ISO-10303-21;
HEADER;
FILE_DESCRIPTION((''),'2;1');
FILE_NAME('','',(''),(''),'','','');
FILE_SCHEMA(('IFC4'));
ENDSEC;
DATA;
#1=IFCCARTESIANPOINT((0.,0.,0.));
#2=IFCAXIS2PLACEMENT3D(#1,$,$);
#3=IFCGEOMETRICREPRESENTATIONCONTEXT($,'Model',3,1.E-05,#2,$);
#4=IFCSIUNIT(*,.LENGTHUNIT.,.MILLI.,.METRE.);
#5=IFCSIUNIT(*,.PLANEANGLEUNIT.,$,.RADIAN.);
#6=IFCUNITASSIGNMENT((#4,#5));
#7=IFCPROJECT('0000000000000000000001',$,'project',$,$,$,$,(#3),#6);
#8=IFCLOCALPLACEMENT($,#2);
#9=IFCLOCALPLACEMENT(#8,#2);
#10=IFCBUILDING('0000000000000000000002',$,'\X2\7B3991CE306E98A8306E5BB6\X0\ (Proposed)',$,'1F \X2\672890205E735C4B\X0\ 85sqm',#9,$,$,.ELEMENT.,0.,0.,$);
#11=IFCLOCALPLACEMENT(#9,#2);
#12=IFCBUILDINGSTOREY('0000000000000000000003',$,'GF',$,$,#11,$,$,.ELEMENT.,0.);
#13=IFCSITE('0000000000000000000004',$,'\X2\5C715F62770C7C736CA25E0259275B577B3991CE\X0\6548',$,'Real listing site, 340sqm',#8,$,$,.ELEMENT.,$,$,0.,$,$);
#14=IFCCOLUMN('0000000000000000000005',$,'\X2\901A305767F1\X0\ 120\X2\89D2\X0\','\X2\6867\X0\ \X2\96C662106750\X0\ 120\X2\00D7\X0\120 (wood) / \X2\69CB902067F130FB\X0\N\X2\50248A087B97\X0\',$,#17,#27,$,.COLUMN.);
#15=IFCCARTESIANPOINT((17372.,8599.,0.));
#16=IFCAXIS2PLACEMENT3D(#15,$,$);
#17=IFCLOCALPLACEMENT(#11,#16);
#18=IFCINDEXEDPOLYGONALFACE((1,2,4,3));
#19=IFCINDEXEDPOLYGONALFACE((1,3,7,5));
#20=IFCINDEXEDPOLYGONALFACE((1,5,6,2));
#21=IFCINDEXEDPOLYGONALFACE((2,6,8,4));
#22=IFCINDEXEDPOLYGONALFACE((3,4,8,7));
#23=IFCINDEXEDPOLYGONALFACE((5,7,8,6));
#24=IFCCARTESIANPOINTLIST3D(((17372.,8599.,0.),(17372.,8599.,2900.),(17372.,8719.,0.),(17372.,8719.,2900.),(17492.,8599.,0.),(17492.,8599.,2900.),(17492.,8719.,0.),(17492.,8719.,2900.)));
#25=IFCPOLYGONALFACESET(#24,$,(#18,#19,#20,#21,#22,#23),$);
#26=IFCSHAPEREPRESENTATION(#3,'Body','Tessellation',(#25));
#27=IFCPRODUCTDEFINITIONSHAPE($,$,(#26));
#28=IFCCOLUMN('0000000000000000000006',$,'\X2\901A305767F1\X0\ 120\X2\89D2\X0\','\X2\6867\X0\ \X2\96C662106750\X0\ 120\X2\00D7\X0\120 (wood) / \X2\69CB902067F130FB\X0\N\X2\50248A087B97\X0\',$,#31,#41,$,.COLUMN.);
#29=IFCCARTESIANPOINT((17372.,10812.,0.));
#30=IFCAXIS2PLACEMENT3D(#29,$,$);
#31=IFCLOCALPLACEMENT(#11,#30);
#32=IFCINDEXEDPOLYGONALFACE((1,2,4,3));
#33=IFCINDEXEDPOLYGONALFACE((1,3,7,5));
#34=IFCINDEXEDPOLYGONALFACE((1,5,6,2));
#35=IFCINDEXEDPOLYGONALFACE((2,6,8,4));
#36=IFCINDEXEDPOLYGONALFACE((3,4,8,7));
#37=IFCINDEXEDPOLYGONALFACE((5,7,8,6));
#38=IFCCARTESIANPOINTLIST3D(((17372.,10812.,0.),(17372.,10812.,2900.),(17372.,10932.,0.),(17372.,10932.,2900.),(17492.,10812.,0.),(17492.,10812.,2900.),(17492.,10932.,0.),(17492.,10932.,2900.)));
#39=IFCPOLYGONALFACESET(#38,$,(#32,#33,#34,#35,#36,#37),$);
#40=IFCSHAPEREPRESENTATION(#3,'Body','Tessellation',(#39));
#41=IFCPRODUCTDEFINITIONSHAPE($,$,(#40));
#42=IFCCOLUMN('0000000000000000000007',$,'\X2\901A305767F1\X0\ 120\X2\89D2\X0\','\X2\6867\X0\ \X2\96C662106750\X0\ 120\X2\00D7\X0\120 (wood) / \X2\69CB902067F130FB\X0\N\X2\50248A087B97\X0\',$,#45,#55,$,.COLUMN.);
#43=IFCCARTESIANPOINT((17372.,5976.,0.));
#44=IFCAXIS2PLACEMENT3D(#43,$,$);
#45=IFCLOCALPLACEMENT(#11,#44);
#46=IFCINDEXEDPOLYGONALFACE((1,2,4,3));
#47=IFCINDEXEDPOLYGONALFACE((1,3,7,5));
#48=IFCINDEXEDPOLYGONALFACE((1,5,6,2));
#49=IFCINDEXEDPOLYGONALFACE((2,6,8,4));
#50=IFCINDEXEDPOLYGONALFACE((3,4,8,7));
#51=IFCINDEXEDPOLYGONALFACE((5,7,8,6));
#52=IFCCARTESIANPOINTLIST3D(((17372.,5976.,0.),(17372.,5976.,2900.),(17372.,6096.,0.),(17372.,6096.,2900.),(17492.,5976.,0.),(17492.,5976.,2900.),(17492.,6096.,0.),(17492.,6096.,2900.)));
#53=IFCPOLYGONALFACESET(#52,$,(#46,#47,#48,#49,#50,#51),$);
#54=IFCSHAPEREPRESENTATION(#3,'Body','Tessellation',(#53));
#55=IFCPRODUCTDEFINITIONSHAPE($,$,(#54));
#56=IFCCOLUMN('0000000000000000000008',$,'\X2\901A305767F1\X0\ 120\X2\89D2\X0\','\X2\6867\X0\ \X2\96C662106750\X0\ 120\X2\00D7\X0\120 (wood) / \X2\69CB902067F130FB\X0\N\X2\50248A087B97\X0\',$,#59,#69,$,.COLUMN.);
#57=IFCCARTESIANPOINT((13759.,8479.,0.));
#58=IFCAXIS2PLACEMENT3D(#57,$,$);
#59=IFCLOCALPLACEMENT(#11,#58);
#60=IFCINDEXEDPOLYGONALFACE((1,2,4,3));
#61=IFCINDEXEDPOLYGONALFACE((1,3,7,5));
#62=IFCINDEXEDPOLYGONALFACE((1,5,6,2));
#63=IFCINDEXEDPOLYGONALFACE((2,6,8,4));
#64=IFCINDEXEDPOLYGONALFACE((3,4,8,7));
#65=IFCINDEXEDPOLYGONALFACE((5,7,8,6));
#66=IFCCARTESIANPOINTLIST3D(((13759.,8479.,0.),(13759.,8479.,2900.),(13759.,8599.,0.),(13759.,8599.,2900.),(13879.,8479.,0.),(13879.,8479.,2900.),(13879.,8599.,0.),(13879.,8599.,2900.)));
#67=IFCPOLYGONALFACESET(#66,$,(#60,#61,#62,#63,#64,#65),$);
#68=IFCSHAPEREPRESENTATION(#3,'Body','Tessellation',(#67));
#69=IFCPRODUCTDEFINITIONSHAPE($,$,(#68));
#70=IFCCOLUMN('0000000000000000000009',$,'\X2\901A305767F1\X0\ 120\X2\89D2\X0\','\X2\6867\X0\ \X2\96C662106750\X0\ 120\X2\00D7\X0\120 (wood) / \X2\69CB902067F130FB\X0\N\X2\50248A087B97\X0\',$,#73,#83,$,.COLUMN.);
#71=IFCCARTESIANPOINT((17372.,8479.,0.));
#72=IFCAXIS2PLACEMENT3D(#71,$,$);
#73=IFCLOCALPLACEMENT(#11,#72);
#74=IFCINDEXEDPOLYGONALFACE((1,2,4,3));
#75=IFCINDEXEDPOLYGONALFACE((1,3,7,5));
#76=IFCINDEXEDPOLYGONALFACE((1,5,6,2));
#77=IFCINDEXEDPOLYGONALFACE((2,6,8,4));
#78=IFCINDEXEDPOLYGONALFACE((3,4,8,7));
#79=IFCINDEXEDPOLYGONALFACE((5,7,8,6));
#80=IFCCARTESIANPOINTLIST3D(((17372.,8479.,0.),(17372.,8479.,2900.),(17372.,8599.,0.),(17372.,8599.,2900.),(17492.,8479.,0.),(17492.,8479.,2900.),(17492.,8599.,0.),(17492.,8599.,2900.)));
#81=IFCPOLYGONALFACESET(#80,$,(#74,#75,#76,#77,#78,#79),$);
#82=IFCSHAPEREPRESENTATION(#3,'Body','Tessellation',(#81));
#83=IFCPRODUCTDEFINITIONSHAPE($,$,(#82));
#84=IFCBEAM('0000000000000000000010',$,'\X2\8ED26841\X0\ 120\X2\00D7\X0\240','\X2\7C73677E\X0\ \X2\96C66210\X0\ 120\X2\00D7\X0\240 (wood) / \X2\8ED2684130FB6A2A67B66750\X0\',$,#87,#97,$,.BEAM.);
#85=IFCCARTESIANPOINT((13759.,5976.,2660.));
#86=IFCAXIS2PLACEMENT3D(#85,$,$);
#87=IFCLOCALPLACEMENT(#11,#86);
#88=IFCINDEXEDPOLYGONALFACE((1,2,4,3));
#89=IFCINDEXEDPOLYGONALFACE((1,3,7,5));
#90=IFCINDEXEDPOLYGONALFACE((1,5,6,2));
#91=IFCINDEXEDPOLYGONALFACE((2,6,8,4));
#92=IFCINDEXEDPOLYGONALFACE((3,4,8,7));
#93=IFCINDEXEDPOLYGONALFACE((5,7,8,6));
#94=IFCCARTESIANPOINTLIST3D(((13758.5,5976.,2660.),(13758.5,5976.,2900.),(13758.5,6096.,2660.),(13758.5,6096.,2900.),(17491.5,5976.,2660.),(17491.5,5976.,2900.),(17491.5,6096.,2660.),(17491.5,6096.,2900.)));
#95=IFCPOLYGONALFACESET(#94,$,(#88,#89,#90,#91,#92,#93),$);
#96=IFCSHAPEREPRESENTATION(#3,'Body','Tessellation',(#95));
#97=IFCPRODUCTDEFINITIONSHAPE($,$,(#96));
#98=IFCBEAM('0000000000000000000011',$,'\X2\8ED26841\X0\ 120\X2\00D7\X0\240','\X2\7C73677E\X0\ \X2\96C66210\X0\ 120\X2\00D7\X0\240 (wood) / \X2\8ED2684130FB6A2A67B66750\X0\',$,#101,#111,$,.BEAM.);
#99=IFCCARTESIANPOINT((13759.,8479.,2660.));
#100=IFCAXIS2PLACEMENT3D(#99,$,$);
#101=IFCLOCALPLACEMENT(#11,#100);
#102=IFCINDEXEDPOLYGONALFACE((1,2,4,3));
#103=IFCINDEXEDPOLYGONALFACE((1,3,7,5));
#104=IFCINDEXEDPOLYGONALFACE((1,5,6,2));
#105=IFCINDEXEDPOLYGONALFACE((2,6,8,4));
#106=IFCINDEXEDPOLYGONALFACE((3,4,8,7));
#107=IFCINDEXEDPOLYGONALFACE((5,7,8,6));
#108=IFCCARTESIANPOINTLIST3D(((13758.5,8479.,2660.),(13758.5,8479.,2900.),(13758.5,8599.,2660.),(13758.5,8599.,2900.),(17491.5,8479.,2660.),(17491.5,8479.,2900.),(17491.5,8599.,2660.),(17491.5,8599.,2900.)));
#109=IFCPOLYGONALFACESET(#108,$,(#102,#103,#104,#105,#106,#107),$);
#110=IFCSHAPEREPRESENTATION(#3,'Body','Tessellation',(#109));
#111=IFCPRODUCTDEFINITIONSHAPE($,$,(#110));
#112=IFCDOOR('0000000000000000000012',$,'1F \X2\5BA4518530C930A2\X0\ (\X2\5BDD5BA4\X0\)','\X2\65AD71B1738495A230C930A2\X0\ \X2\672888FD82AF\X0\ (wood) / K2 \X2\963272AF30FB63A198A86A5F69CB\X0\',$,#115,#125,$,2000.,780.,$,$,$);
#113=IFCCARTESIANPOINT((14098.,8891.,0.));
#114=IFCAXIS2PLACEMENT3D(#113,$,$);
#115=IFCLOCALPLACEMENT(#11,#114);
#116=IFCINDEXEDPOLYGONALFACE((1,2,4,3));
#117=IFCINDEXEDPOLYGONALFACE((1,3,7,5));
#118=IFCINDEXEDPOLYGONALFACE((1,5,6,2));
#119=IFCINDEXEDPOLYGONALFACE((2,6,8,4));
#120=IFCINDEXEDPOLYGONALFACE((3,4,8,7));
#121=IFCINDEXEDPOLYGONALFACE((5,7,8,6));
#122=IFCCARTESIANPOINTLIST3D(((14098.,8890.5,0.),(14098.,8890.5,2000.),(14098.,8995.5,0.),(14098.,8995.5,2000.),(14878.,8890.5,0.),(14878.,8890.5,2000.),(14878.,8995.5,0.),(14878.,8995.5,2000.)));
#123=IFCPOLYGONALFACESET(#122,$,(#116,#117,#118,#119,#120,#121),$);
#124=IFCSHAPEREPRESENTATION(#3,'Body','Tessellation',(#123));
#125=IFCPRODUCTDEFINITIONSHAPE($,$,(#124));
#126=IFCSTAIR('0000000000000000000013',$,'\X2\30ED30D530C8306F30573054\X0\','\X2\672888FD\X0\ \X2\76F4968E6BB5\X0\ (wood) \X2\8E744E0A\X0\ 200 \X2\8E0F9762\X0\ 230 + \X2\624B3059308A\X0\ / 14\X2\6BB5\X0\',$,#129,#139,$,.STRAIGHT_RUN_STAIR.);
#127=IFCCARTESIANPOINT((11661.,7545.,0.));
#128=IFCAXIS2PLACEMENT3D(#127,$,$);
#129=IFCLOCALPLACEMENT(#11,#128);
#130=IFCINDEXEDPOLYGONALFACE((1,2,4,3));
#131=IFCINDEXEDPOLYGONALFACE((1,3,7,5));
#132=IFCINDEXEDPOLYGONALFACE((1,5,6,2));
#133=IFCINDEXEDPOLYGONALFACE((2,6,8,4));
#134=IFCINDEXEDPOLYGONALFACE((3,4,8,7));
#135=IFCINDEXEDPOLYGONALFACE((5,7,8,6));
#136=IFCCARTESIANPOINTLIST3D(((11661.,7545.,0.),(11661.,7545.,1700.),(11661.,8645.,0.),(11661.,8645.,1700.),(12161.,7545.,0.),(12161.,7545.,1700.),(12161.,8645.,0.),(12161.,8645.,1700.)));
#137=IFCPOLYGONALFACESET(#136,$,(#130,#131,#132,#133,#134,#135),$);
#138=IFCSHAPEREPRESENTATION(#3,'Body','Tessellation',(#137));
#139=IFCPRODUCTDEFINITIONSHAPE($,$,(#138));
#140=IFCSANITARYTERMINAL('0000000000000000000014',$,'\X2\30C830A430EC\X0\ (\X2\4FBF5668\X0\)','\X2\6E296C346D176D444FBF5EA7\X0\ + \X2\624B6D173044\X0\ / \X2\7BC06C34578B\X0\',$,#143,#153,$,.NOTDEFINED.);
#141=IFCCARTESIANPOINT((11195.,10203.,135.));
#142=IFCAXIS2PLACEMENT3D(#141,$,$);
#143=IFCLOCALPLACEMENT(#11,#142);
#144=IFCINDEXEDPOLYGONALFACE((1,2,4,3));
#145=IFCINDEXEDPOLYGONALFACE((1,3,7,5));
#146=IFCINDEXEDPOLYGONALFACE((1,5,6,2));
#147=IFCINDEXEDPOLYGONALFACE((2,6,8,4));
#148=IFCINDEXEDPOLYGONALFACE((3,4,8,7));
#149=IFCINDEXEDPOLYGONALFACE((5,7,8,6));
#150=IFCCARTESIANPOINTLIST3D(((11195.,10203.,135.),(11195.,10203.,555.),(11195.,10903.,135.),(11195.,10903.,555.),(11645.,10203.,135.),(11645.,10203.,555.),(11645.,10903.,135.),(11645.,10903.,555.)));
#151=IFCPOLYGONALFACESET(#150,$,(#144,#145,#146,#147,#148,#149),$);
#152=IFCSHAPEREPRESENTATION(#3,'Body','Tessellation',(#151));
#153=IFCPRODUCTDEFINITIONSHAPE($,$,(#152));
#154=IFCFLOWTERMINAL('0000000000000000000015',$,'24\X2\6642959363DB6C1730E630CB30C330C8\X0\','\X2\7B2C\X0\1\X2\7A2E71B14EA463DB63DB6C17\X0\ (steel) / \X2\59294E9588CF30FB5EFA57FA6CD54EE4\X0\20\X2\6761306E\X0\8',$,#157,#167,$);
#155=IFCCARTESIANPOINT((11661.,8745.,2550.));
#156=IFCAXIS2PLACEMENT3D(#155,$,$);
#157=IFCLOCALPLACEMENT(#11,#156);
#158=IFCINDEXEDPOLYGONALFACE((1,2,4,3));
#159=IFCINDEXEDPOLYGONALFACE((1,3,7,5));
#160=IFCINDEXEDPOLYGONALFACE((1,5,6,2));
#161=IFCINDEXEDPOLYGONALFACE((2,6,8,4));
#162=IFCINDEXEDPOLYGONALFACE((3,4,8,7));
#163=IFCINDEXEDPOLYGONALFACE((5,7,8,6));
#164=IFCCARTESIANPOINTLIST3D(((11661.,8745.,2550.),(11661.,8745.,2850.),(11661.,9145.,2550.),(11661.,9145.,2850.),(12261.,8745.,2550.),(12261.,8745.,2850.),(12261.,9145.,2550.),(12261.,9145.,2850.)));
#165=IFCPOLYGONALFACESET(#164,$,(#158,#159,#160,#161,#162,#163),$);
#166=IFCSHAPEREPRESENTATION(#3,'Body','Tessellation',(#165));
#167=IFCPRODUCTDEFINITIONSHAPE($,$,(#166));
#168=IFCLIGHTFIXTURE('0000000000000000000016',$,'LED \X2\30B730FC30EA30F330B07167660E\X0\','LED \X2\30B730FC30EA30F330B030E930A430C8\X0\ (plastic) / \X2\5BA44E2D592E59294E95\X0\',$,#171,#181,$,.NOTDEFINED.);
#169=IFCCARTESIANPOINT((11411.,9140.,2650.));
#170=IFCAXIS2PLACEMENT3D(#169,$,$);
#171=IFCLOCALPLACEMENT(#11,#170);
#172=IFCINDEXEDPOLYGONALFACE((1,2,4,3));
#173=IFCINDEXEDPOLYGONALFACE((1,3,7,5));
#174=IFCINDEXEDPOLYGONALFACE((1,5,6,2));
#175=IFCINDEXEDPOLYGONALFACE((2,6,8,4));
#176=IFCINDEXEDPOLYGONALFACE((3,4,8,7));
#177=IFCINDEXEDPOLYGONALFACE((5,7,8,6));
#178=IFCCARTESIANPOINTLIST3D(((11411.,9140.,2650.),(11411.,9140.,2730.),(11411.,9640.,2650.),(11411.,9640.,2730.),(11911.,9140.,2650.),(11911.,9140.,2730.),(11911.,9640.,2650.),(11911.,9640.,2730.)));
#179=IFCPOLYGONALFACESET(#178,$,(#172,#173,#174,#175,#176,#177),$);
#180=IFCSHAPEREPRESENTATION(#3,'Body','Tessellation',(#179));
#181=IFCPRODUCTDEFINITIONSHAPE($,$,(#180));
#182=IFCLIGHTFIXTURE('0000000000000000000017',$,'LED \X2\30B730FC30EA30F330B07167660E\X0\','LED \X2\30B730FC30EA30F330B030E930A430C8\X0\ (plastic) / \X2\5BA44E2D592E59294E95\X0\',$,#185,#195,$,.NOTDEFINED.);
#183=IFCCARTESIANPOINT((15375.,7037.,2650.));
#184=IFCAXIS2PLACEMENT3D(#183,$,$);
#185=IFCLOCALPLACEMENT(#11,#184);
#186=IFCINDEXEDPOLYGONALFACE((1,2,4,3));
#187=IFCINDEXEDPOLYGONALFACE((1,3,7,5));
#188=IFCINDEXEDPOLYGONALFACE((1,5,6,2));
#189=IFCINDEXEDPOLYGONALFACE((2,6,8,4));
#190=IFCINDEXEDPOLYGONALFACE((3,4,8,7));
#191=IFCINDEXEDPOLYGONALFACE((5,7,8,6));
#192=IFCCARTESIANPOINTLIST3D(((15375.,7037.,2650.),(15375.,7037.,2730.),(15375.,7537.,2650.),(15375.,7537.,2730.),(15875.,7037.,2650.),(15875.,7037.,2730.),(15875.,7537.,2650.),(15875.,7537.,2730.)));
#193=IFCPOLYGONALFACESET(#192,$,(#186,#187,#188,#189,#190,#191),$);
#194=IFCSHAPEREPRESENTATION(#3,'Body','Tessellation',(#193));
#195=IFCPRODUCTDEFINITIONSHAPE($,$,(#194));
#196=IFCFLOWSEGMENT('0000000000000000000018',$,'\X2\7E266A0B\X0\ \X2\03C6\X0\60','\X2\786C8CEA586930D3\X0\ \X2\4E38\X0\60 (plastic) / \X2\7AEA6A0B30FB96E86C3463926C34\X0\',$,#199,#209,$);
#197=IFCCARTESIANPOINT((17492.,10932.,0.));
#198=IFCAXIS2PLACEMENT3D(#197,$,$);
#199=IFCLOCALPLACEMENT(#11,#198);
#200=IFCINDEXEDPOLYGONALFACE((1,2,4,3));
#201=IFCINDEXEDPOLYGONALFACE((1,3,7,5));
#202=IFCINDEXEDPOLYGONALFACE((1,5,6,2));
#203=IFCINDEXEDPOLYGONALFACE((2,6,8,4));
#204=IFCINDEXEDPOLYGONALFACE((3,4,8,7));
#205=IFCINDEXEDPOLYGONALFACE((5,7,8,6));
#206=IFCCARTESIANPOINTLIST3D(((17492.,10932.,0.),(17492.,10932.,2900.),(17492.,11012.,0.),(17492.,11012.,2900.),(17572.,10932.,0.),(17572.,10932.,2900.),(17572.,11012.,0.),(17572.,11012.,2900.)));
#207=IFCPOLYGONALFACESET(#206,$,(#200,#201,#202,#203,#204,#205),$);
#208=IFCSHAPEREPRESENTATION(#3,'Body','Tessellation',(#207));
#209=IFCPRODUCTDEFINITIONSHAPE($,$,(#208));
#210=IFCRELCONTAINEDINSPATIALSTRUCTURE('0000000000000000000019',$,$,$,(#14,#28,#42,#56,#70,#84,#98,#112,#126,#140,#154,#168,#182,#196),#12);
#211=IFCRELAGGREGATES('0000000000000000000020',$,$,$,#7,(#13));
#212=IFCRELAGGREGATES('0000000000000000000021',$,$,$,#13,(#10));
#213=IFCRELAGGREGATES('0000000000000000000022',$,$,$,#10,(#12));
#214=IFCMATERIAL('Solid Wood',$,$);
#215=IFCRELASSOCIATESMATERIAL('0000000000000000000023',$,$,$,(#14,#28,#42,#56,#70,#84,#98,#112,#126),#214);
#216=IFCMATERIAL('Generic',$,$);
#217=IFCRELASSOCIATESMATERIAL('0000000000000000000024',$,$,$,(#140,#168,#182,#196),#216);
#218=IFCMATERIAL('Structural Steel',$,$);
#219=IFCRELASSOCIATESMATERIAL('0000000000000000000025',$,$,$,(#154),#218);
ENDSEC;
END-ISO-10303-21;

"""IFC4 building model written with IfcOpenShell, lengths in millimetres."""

from ifc_helpers import new_model, si_unit, frame, frame_2d, origin, place, context, project, spatial, rectangle, extrude, material, element, save


model = new_model("IFC4")

# Units and contexts
model_context = context("Model", 3, precision=1e-05, world=origin())
ifc_project = project(units=[si_unit("LENGTHUNIT", "METRE", prefix="MILLI"), si_unit("PLANEANGLEUNIT", "RADIAN")], contexts=[model_context])

# Site, building, storey
site_placement = place(None, origin())
site = spatial("IfcSite", under=ifc_project, at=site_placement, Name="山形県米沢市大字笹野6548", ObjectType="Real listing site, 340sqm", CompositionType="ELEMENT", RefElevation=0.0)
building_placement = place(site_placement, origin())
building = spatial("IfcBuilding", under=site, at=building_placement, Name="笹野の風の家 (Proposed)", ObjectType="1F 木造平屋 85sqm", CompositionType="ELEMENT", ElevationOfRefHeight=0.0, ElevationOfTerrain=0.0)
storey_placement = place(building_placement, origin())
storey = spatial("IfcBuildingStorey", under=building, at=storey_placement, Name="GF", CompositionType="ELEMENT", Elevation=0.0)

# Columns
ifc_material_1 = material(Name="Solid Wood")
column_1_placement = place(storey_placement, frame((17372.0, 8599.0, 0.0)))
element("IfcColumn", 1, at=column_1_placement, inside=storey, material=ifc_material_1, Name="通し柱 120角", Description="桧 集成材 120×120 (wood) / 構造柱・N値計算", PredefinedType="COLUMN", context=model_context, shape_type="SweptSolid", body=[
    extrude(rectangle(XDim=120.0, YDim=120.0, at=frame_2d((60.0, 60.0))), frame((17372.0, 8599.0, 0.0)), (0.0, 0.0, 1.0), 2900.0),
])
column_2_placement = place(storey_placement, frame((17372.0, 10812.0, 0.0)))
element("IfcColumn", 2, at=column_2_placement, inside=storey, material=ifc_material_1, Name="通し柱 120角", Description="桧 集成材 120×120 (wood) / 構造柱・N値計算", PredefinedType="COLUMN", context=model_context, shape_type="SweptSolid", body=[
    extrude(rectangle(XDim=120.0, YDim=120.0, at=frame_2d((60.0, 60.0))), frame((17372.0, 10812.0, 0.0)), (0.0, 0.0, 1.0), 2900.0),
])
column_3_placement = place(storey_placement, frame((17372.0, 5976.0, 0.0)))
element("IfcColumn", 3, at=column_3_placement, inside=storey, material=ifc_material_1, Name="通し柱 120角", Description="桧 集成材 120×120 (wood) / 構造柱・N値計算", PredefinedType="COLUMN", context=model_context, shape_type="SweptSolid", body=[
    extrude(rectangle(XDim=120.0, YDim=120.0, at=frame_2d((60.0, 60.0))), frame((17372.0, 5976.0, 0.0)), (0.0, 0.0, 1.0), 2900.0),
])
column_4_placement = place(storey_placement, frame((13759.0, 8479.0, 0.0)))
element("IfcColumn", 4, at=column_4_placement, inside=storey, material=ifc_material_1, Name="通し柱 120角", Description="桧 集成材 120×120 (wood) / 構造柱・N値計算", PredefinedType="COLUMN", context=model_context, shape_type="SweptSolid", body=[
    extrude(rectangle(XDim=120.0, YDim=120.0, at=frame_2d((60.0, 60.0))), frame((13759.0, 8479.0, 0.0)), (0.0, 0.0, 1.0), 2900.0),
])
column_5_placement = place(storey_placement, frame((17372.0, 8479.0, 0.0)))
element("IfcColumn", 5, at=column_5_placement, inside=storey, material=ifc_material_1, Name="通し柱 120角", Description="桧 集成材 120×120 (wood) / 構造柱・N値計算", PredefinedType="COLUMN", context=model_context, shape_type="SweptSolid", body=[
    extrude(rectangle(XDim=120.0, YDim=120.0, at=frame_2d((60.0, 60.0))), frame((17372.0, 8479.0, 0.0)), (0.0, 0.0, 1.0), 2900.0),
])

# Beams
beam_1_placement = place(storey_placement, frame((13759.0, 5976.0, 2660.0)))
element("IfcBeam", 6, at=beam_1_placement, inside=storey, material=ifc_material_1, Name="軒桁 120×240", Description="米松 集成 120×240 (wood) / 軒桁・横架材", PredefinedType="BEAM", context=model_context, shape_type="SweptSolid", body=[
    extrude(rectangle(XDim=3733.0, YDim=120.0, at=frame_2d((1866.0, 60.0))), frame((13759.0, 5976.0, 2660.0)), (0.0, 0.0, 1.0), 240.0),
])
beam_2_placement = place(storey_placement, frame((13759.0, 8479.0, 2660.0)))
element("IfcBeam", 7, at=beam_2_placement, inside=storey, material=ifc_material_1, Name="軒桁 120×240", Description="米松 集成 120×240 (wood) / 軒桁・横架材", PredefinedType="BEAM", context=model_context, shape_type="SweptSolid", body=[
    extrude(rectangle(XDim=3733.0, YDim=120.0, at=frame_2d((1866.0, 60.0))), frame((13759.0, 8479.0, 2660.0)), (0.0, 0.0, 1.0), 240.0),
])

# Door
door_placement = place(storey_placement, frame((14098.0, 8891.0, 0.0)))
element("IfcDoor", 8, at=door_placement, inside=storey, material=ifc_material_1, Name="1F 室内ドア (寝室)", Description="断熱玄関ドア 木製芯 (wood) / K2 防犯・採風機構", OverallHeight=2000.0, OverallWidth=780.0, context=model_context, shape_type="SweptSolid", body=[
    extrude(rectangle(XDim=780.0, YDim=105.0, at=frame_2d((390.0, 52.0))), frame((14098.0, 8891.0, 0.0)), (0.0, 0.0, 1.0), 2000.0),
])

# Stair
stair_placement = place(storey_placement, frame((11661.0, 7545.0, 0.0)))
element("IfcStair", 9, at=stair_placement, inside=storey, material=ifc_material_1, Name="ロフトはしご", Description="木製 直階段 (wood) 蹴上 200 踏面 230 + 手すり / 14段", PredefinedType="STRAIGHT_RUN_STAIR", context=model_context, shape_type="SweptSolid", body=[
    extrude(rectangle(XDim=500.0, YDim=1100.0, at=frame_2d((250.0, 550.0))), frame((11661.0, 7545.0, 0.0)), (0.0, 0.0, 1.0), 1700.0),
])

# Shared definitions
ifc_material_2 = material(Name="Generic")

# Sanitary terminal
sanitary_terminal_placement = place(storey_placement, frame((11195.0, 10203.0, 135.0)))
element("IfcSanitaryTerminal", 10, at=sanitary_terminal_placement, inside=storey, material=ifc_material_2, Name="トイレ (便器)", Description="温水洗浄便座 + 手洗い / 節水型", PredefinedType="NOTDEFINED", context=model_context, shape_type="SweptSolid", body=[
    extrude(rectangle(XDim=450.0, YDim=700.0, at=frame_2d((225.0, 350.0))), frame((11195.0, 10203.0, 135.0)), (0.0, 0.0, 1.0), 420.0),
])

# Flow terminal
ifc_material_3 = material(Name="Structural Steel")
flow_terminal_placement = place(storey_placement, frame((11661.0, 8745.0, 2550.0)))
element("IfcFlowTerminal", 11, at=flow_terminal_placement, inside=storey, material=ifc_material_3, Name="24時間換気ユニット", Description="第1種熱交換換気 (steel) / 天井裏・建基法令20条の8", context=model_context, shape_type="SweptSolid", body=[
    extrude(rectangle(XDim=600.0, YDim=400.0, at=frame_2d((300.0, 200.0))), frame((11661.0, 8745.0, 2550.0)), (0.0, 0.0, 1.0), 300.0),
])

# Light fixtures
light_fixture_1_placement = place(storey_placement, frame((11411.0, 9140.0, 2650.0)))
element("IfcLightFixture", 12, at=light_fixture_1_placement, inside=storey, material=ifc_material_2, Name="LED シーリング照明", Description="LED シーリングライト (plastic) / 室中央天井", PredefinedType="NOTDEFINED", context=model_context, shape_type="SweptSolid", body=[
    extrude(rectangle(XDim=500.0, YDim=500.0, at=frame_2d((250.0, 250.0))), frame((11411.0, 9140.0, 2650.0)), (0.0, 0.0, 1.0), 80.0),
])
light_fixture_2_placement = place(storey_placement, frame((15375.0, 7037.0, 2650.0)))
element("IfcLightFixture", 13, at=light_fixture_2_placement, inside=storey, material=ifc_material_2, Name="LED シーリング照明", Description="LED シーリングライト (plastic) / 室中央天井", PredefinedType="NOTDEFINED", context=model_context, shape_type="SweptSolid", body=[
    extrude(rectangle(XDim=500.0, YDim=500.0, at=frame_2d((250.0, 250.0))), frame((15375.0, 7037.0, 2650.0)), (0.0, 0.0, 1.0), 80.0),
])

# Flow segment
flow_segment_placement = place(storey_placement, frame((17492.0, 10932.0, 0.0)))
element("IfcFlowSegment", 14, at=flow_segment_placement, inside=storey, material=ifc_material_2, Name="縦樋 φ60", Description="硬質塩ビ 丸60 (plastic) / 竪樋・雨水排水", context=model_context, shape_type="SweptSolid", body=[
    extrude(rectangle(XDim=80.0, YDim=80.0, at=frame_2d((40.0, 40.0))), frame((17492.0, 10932.0, 0.0)), (0.0, 0.0, 1.0), 2900.0),
])

save(model, "model.ifc")
